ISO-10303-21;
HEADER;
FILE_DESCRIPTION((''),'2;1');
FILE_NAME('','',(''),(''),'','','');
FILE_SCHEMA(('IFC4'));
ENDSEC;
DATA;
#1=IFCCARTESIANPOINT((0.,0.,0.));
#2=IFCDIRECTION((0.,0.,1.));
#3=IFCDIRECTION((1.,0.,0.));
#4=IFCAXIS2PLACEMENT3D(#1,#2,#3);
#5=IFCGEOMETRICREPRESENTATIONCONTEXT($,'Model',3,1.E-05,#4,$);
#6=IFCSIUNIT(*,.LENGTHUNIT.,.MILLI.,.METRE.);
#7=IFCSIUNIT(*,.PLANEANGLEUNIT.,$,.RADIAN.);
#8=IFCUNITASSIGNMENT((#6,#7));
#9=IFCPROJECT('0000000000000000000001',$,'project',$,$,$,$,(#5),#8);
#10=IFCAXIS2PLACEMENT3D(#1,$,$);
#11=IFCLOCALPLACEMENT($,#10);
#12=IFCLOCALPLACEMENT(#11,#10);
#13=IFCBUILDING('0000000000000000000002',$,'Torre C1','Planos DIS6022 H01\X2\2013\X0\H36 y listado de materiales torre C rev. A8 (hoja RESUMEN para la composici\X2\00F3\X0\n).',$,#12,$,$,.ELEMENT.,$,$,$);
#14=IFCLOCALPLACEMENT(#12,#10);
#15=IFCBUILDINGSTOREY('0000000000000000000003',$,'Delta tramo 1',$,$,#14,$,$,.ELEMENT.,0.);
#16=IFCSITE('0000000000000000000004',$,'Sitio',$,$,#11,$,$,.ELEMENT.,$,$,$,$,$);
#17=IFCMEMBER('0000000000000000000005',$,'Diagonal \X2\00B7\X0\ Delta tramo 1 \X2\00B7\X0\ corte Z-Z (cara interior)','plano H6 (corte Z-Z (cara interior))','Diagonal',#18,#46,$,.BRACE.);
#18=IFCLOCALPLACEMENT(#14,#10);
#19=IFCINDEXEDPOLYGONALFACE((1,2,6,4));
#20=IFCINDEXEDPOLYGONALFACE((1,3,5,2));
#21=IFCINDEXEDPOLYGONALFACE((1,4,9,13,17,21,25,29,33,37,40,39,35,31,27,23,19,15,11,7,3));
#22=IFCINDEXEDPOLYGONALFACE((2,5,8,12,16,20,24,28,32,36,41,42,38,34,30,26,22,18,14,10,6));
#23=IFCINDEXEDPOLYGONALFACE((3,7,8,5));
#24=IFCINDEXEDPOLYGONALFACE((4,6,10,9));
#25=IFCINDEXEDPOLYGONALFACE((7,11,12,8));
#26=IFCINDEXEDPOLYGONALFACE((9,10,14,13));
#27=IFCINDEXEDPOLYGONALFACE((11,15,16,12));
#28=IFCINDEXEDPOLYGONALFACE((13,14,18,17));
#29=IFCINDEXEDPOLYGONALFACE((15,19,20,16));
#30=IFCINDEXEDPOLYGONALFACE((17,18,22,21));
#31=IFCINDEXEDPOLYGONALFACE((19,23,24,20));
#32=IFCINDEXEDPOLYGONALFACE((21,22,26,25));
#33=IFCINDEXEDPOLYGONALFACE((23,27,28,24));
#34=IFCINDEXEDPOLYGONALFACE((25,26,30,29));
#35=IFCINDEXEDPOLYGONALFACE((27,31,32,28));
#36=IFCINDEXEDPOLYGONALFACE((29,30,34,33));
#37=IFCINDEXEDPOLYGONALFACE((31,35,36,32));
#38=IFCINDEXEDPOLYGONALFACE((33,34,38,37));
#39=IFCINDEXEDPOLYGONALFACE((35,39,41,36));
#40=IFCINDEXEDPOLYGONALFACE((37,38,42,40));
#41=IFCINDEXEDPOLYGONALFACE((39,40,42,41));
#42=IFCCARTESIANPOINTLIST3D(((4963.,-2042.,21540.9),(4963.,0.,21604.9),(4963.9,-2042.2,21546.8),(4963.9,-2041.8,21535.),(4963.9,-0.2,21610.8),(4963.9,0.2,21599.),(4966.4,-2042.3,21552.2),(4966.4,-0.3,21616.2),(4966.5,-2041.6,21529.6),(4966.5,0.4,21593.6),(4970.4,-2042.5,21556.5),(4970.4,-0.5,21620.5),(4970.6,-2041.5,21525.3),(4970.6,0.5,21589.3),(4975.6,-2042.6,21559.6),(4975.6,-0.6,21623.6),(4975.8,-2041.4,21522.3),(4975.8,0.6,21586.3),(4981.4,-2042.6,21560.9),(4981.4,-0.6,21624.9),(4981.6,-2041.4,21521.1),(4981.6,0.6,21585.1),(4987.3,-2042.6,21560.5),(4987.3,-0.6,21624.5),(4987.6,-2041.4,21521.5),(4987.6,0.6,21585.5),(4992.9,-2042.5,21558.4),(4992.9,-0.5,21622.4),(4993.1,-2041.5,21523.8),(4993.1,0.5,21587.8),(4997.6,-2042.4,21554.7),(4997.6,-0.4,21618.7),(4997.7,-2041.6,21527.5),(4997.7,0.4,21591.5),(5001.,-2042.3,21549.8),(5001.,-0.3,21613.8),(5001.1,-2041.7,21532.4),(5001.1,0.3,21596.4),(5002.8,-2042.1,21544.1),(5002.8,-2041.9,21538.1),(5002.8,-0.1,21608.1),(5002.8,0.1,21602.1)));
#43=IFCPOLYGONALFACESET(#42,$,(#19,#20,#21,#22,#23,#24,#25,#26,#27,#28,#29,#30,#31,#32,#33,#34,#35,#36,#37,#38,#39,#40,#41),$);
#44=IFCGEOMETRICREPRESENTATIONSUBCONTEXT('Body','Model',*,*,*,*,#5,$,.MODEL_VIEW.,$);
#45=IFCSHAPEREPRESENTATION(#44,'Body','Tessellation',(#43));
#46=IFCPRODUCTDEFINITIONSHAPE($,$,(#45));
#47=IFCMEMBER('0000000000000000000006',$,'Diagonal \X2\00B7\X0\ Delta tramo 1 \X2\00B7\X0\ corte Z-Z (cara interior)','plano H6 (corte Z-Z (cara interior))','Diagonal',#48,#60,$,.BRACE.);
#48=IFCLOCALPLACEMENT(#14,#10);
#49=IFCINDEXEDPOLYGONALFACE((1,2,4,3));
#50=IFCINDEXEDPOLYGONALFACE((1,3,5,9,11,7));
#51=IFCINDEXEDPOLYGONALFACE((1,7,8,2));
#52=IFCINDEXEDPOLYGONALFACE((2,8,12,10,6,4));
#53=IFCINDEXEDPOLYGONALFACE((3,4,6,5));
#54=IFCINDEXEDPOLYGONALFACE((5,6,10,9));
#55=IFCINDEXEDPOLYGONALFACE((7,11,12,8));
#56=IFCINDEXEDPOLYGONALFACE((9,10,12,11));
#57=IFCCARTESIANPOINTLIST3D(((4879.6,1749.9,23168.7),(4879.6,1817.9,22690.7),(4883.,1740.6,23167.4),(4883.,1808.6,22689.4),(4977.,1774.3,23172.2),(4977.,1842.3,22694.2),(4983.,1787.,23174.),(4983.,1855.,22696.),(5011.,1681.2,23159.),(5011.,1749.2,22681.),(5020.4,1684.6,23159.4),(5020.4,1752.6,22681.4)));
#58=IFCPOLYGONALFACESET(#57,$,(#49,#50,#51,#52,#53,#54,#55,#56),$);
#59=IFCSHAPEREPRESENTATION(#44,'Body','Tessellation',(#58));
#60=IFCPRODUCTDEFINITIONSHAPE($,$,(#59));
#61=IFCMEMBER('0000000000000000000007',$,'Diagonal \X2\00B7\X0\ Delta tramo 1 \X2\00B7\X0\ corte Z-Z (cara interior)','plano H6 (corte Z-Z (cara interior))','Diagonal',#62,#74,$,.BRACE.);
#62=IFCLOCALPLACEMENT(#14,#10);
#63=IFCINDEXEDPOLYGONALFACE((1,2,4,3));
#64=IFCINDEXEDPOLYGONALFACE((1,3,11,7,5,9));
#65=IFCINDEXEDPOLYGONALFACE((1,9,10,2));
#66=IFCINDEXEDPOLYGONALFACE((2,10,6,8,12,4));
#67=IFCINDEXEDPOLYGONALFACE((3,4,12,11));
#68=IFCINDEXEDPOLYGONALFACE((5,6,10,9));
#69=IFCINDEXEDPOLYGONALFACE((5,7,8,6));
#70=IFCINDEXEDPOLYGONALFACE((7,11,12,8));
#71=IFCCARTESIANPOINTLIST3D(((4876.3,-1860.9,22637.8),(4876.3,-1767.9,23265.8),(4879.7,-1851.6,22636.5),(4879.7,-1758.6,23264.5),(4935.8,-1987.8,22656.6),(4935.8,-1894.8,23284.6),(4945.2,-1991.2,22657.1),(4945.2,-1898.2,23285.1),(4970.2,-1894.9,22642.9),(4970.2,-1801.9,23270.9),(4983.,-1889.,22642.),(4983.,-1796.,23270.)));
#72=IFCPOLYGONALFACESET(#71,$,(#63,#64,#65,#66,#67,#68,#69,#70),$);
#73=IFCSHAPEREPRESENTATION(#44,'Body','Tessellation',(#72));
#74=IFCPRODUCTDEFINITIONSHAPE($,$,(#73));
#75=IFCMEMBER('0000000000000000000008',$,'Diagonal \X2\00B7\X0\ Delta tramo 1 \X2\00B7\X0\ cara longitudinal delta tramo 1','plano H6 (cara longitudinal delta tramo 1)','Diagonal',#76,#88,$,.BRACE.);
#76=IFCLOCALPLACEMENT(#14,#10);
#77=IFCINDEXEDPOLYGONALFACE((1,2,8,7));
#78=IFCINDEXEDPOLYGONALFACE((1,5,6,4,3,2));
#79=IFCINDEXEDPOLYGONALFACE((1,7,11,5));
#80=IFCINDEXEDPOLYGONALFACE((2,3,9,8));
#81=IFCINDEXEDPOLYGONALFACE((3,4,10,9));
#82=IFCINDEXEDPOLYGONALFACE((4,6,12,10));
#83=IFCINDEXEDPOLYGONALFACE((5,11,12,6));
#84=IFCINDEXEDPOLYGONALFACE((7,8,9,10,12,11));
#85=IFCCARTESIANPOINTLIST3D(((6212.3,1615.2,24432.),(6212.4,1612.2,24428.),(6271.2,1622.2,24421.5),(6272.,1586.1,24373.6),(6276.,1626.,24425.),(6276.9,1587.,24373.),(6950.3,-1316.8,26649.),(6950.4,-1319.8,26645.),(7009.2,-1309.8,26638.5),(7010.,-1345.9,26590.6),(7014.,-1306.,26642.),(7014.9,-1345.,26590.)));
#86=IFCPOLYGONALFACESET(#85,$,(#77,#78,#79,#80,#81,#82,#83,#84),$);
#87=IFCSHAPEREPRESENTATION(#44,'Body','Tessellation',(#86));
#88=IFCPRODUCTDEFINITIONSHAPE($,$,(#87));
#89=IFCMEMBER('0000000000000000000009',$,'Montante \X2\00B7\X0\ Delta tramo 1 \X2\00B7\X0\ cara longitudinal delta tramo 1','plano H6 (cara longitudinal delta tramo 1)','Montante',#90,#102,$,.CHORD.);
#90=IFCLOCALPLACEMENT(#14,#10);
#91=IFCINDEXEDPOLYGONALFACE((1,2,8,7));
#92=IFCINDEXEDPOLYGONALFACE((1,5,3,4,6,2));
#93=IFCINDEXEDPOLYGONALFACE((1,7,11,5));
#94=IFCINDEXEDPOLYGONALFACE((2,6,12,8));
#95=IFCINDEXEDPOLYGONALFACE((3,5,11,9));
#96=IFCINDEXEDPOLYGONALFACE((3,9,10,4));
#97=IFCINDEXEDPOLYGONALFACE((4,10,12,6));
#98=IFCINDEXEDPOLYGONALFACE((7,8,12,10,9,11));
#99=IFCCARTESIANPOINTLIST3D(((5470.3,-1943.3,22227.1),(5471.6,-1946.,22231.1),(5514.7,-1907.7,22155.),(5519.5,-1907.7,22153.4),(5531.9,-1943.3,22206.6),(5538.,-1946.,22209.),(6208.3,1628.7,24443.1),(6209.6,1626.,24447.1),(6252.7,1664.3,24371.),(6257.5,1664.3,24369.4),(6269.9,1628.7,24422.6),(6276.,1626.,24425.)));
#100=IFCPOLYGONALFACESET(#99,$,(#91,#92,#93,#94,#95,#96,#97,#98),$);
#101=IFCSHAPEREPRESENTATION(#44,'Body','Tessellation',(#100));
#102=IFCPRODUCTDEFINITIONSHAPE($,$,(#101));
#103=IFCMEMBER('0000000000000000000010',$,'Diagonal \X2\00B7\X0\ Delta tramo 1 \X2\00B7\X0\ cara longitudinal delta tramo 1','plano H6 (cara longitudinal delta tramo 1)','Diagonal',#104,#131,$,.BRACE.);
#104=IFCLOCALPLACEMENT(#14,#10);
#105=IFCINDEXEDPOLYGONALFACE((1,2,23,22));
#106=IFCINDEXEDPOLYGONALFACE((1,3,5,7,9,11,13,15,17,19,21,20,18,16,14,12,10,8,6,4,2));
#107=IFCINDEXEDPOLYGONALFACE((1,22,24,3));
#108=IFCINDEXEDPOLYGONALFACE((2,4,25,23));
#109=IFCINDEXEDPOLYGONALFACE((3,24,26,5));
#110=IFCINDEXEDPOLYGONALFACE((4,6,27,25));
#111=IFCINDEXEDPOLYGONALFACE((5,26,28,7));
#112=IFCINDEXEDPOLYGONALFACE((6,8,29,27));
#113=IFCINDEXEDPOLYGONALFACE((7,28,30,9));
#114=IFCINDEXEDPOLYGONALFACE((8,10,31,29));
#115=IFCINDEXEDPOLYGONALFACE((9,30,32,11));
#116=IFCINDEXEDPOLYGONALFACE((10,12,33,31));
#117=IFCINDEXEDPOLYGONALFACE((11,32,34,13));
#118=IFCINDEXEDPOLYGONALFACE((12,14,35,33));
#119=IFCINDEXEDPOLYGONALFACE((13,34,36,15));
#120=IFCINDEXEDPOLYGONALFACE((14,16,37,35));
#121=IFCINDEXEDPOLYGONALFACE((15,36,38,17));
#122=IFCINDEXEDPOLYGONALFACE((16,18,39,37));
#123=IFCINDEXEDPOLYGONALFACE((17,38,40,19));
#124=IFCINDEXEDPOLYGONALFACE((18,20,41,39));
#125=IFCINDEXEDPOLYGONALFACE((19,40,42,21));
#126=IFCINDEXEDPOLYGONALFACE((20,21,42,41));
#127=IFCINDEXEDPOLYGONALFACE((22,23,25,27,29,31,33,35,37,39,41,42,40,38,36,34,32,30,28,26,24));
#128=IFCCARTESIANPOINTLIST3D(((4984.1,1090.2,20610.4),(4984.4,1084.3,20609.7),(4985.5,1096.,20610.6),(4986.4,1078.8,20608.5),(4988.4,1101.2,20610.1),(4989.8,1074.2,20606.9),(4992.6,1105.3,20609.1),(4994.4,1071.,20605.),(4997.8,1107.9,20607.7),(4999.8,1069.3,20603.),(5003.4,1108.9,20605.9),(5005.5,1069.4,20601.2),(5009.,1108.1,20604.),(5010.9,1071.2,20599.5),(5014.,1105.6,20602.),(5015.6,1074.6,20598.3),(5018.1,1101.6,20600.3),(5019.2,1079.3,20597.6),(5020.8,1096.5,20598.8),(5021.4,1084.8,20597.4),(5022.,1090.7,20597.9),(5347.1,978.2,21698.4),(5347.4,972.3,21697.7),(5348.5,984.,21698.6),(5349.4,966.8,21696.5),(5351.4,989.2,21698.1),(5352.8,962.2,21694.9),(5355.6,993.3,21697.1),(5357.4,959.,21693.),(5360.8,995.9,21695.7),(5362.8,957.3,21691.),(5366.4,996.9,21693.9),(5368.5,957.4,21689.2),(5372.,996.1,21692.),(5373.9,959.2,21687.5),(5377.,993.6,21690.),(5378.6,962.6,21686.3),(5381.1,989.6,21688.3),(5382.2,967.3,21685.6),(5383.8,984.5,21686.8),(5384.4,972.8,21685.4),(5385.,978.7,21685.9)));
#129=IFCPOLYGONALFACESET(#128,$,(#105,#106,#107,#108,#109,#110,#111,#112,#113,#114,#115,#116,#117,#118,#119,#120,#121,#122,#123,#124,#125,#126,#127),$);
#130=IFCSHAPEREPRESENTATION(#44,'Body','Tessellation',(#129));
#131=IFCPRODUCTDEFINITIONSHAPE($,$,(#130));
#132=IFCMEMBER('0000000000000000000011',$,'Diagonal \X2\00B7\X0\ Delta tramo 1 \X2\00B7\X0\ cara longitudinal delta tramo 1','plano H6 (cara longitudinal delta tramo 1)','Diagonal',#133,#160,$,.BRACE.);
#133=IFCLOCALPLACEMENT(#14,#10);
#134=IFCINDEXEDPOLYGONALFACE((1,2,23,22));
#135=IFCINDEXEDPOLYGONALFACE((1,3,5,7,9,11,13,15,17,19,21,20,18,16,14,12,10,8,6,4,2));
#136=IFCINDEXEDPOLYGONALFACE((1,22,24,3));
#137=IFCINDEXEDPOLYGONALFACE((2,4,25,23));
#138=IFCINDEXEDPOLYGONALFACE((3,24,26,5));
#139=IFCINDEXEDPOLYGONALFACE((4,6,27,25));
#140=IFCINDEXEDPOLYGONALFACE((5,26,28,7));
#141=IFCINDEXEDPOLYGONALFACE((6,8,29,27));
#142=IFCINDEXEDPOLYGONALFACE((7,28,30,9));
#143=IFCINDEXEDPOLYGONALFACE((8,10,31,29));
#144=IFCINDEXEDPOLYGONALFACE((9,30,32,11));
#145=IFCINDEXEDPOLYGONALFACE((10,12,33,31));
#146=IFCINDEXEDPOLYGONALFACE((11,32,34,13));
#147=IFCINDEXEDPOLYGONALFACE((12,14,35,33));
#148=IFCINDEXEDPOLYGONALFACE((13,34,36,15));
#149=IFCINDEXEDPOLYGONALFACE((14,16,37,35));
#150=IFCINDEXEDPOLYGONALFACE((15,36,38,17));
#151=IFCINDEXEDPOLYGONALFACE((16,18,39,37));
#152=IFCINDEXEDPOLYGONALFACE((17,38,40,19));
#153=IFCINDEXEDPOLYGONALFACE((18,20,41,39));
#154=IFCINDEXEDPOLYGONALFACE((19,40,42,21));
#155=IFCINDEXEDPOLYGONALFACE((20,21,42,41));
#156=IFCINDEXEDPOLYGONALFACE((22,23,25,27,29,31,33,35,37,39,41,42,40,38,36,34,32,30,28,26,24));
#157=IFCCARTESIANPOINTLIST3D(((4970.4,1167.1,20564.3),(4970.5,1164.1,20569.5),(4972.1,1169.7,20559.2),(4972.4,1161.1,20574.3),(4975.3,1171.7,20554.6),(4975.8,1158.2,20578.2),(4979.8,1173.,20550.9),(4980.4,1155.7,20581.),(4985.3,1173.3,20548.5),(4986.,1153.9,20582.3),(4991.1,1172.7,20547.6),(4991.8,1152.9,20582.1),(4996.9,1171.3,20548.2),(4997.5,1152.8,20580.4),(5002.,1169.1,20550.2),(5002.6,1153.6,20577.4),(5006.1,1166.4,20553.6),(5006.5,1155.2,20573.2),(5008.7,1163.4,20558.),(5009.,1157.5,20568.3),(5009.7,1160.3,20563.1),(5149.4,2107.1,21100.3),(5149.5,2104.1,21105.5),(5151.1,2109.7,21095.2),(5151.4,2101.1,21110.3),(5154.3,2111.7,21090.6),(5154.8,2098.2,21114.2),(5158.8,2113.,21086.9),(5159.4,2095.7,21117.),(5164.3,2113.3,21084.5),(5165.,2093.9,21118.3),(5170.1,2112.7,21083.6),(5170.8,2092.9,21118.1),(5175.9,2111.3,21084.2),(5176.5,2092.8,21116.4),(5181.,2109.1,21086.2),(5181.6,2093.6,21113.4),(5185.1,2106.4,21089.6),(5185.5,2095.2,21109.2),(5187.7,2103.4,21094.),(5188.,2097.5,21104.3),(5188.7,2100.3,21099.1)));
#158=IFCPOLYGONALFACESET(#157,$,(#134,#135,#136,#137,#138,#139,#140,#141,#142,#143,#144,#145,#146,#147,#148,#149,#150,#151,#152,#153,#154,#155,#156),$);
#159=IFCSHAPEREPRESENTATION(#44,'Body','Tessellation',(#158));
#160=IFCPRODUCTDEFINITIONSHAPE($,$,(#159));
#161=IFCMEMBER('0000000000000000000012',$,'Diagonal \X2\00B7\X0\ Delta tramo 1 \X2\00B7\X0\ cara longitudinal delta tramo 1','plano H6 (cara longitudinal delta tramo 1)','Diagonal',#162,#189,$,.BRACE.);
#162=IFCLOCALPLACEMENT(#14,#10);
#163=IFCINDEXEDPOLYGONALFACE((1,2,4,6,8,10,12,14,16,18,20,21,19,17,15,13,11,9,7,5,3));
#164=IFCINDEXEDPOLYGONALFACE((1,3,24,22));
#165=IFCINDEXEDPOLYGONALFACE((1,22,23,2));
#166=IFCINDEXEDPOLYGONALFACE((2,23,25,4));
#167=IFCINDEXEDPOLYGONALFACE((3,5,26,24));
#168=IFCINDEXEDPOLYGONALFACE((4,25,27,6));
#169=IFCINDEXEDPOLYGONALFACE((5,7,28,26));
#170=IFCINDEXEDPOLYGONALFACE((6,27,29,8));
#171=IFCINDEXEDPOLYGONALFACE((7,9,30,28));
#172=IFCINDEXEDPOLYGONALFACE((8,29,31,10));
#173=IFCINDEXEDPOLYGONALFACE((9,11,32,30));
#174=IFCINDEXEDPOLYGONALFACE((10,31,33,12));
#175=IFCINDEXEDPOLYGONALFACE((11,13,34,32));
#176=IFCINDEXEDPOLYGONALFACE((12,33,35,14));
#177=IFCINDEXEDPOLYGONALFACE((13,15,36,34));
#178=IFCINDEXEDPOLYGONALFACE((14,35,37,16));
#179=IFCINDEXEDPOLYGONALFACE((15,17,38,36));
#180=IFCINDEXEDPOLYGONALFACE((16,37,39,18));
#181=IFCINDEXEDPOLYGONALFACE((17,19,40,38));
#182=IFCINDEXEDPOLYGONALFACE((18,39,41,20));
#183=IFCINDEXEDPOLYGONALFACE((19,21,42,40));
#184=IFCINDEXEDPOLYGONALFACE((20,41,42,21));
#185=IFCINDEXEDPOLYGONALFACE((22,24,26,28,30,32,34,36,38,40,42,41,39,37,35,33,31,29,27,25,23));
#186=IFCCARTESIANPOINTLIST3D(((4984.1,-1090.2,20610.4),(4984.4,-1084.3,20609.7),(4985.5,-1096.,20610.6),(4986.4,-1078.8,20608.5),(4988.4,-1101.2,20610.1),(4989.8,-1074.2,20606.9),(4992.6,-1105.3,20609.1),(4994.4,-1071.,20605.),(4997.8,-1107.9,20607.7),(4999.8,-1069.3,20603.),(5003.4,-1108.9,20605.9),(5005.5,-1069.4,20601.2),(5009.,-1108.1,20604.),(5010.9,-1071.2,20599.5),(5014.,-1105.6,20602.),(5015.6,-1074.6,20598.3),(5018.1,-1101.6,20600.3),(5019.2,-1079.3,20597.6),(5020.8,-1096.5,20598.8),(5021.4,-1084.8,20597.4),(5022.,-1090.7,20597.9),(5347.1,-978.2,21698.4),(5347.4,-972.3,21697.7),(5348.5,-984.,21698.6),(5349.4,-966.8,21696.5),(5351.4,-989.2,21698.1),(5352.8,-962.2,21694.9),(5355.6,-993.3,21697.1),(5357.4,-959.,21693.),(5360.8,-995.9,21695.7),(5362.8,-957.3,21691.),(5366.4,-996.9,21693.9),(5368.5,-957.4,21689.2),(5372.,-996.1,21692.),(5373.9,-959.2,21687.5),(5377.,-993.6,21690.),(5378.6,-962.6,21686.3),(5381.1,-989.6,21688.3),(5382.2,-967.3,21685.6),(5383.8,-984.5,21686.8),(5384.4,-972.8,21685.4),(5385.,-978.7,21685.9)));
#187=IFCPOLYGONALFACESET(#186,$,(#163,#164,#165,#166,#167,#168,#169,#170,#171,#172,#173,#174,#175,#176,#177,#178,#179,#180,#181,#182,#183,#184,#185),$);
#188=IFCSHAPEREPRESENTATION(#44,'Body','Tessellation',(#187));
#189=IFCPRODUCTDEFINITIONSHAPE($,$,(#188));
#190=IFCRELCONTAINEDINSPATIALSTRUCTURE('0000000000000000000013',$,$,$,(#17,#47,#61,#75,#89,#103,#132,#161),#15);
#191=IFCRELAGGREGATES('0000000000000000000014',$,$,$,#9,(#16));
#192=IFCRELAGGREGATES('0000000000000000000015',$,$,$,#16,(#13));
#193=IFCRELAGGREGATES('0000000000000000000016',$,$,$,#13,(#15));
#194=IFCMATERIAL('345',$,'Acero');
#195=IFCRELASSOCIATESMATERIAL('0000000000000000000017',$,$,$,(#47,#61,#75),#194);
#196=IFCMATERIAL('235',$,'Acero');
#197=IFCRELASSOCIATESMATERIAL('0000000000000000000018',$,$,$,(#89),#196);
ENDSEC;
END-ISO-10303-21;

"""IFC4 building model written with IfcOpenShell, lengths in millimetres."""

from ifc_helpers import new_model, si_unit, frame, frame_2d, origin, origin_with_axes, place, context, subcontext, project, spatial, circle, l_section, extrude, material, element, save


model = new_model("IFC4")

# Units and contexts
model_context = context("Model", 3, precision=1e-05, world=origin_with_axes())
body_context = subcontext(model_context, "Body", "Model", "MODEL_VIEW")
ifc_project = project(units=[si_unit("LENGTHUNIT", "METRE", prefix="MILLI"), si_unit("PLANEANGLEUNIT", "RADIAN")], contexts=[model_context])

# Site, building, storey
site_placement = place(None, origin())
site = spatial("IfcSite", under=ifc_project, at=site_placement, Name="Sitio", CompositionType="ELEMENT")
building_placement = place(site_placement, origin())
building = spatial("IfcBuilding", under=site, at=building_placement, Name="Torre C1", Description="Planos DIS6022 H01–H36 y listado de materiales torre C rev. A8 (hoja RESUMEN para la composición).", CompositionType="ELEMENT")
storey_placement = place(building_placement, origin())
storey = spatial("IfcBuildingStorey", under=building, at=storey_placement, Name="Delta tramo 1", CompositionType="ELEMENT", Elevation=0.0)

# Members
ifc_material_1 = material(Name="235", Category="Acero")
member_1_placement = place(storey_placement, frame((4983.0, -2042.0, 21541.0), z_axis=(0.0, 0.999509, 0.031326), x_axis=(-0.999979, 0.000201, -0.006415)))
element("IfcMember", 1, at=member_1_placement, inside=storey, Name="Diagonal · Delta tramo 1 · corte Z-Z (cara interior)", Description="plano H6 (corte Z-Z (cara interior))", ObjectType="Diagonal", PredefinedType="BRACE", context=body_context, shape_type="SweptSolid", body=[
    extrude(circle(Radius=20.0), None, (0.0, 0.0, 1.0), 2043.0),
])
ifc_material_2 = material(Name="345", Category="Acero")
member_2_placement = place(storey_placement, frame((4983.0, 1855.0, 22696.0), z_axis=(0.0, -0.140841, 0.990032), x_axis=(-0.940347, -0.336826, -0.047917)))
element("IfcMember", 2, at=member_2_placement, inside=storey, material=ifc_material_2, Name="Diagonal · Delta tramo 1 · corte Z-Z (cara interior)", Description="plano H6 (corte Z-Z (cara interior))", ObjectType="Diagonal", PredefinedType="BRACE", context=body_context, shape_type="SweptSolid", body=[
    extrude(l_section(Depth=110.0, Width=110.0, Thickness=10.0, at=frame_2d((55.0, 55.0))), None, (0.0, 0.0, 1.0), 482.8),
])
member_3_placement = place(storey_placement, frame((4983.0, -1889.0, 22642.0), z_axis=(0.0, 0.146492, 0.989212), x_axis=(-0.939149, 0.339805, -0.050321)))
element("IfcMember", 3, at=member_3_placement, inside=storey, material=ifc_material_2, Name="Diagonal · Delta tramo 1 · corte Z-Z (cara interior)", Description="plano H6 (corte Z-Z (cara interior))", ObjectType="Diagonal", PredefinedType="BRACE", context=body_context, shape_type="SweptSolid", body=[
    extrude(l_section(Depth=110.0, Width=110.0, Thickness=10.0, at=frame_2d((55.0, 55.0))), None, (0.0, 0.0, 1.0), 634.8),
])
member_4_placement = place(storey_placement, frame((6276.0, 1626.0, 24425.0), z_axis=(0.196843, -0.782037, 0.591329), x_axis=(-0.980328, -0.165892, 0.106941)))
element("IfcMember", 4, at=member_4_placement, inside=storey, material=ifc_material_2, Name="Diagonal · Delta tramo 1 · cara longitudinal delta tramo 1", Description="plano H6 (cara longitudinal delta tramo 1)", ObjectType="Diagonal", PredefinedType="BRACE", context=body_context, shape_type="SweptSolid", body=[
    extrude(l_section(Depth=65.0, Width=65.0, Thickness=5.0, at=frame_2d((32.5, 32.5))), None, (0.0, 0.0, 1.0), 3749.2),
])
member_5_placement = place(storey_placement, frame((5538.0, -1946.0, 22209.0), z_axis=(0.172921, 0.836957, 0.519232), x_axis=(-0.264454, 0.547269, -0.794079)))
element("IfcMember", 5, at=member_5_placement, inside=storey, material=ifc_material_1, Name="Montante · Delta tramo 1 · cara longitudinal delta tramo 1", Description="plano H6 (cara longitudinal delta tramo 1)", ObjectType="Montante", PredefinedType="CHORD", context=body_context, shape_type="SweptSolid", body=[
    extrude(l_section(Depth=70.0, Width=70.0, Thickness=5.0, at=frame_2d((35.0, 35.0))), None, (0.0, 0.0, 1.0), 4267.8),
])
member_6_placement = place(storey_placement, frame((5366.0, 977.0, 21692.0), z_axis=(-0.314991, 0.097187, -0.944106), x_axis=(-0.929313, -0.233618, 0.286007)))
element("IfcMember", 6, at=member_6_placement, inside=storey, Name="Diagonal · Delta tramo 1 · cara longitudinal delta tramo 1", Description="plano H6 (cara longitudinal delta tramo 1)", ObjectType="Diagonal", PredefinedType="BRACE", context=body_context, shape_type="SweptSolid", body=[
    extrude(circle(Radius=20.0), None, (0.0, 0.0, 1.0), 1152.4),
])
member_7_placement = place(storey_placement, frame((5169.0, 2103.0, 21101.0), z_axis=(-0.163204, -0.85705, -0.488701), x_axis=(-0.972761, 0.057136, 0.224657)))
element("IfcMember", 7, at=member_7_placement, inside=storey, Name="Diagonal · Delta tramo 1 · cara longitudinal delta tramo 1", Description="plano H6 (cara longitudinal delta tramo 1)", ObjectType="Diagonal", PredefinedType="BRACE", context=body_context, shape_type="SweptSolid", body=[
    extrude(circle(Radius=20.0), None, (0.0, 0.0, 1.0), 1096.8),
])
member_8_placement = place(storey_placement, frame((5366.0, -977.0, 21692.0), z_axis=(-0.314991, -0.097187, -0.944106), x_axis=(-0.929313, 0.233618, 0.286007)))
element("IfcMember", 8, at=member_8_placement, inside=storey, Name="Diagonal · Delta tramo 1 · cara longitudinal delta tramo 1", Description="plano H6 (cara longitudinal delta tramo 1)", ObjectType="Diagonal", PredefinedType="BRACE", context=body_context, shape_type="SweptSolid", body=[
    extrude(circle(Radius=20.0), None, (0.0, 0.0, 1.0), 1152.4),
])

save(model, "model.ifc")
